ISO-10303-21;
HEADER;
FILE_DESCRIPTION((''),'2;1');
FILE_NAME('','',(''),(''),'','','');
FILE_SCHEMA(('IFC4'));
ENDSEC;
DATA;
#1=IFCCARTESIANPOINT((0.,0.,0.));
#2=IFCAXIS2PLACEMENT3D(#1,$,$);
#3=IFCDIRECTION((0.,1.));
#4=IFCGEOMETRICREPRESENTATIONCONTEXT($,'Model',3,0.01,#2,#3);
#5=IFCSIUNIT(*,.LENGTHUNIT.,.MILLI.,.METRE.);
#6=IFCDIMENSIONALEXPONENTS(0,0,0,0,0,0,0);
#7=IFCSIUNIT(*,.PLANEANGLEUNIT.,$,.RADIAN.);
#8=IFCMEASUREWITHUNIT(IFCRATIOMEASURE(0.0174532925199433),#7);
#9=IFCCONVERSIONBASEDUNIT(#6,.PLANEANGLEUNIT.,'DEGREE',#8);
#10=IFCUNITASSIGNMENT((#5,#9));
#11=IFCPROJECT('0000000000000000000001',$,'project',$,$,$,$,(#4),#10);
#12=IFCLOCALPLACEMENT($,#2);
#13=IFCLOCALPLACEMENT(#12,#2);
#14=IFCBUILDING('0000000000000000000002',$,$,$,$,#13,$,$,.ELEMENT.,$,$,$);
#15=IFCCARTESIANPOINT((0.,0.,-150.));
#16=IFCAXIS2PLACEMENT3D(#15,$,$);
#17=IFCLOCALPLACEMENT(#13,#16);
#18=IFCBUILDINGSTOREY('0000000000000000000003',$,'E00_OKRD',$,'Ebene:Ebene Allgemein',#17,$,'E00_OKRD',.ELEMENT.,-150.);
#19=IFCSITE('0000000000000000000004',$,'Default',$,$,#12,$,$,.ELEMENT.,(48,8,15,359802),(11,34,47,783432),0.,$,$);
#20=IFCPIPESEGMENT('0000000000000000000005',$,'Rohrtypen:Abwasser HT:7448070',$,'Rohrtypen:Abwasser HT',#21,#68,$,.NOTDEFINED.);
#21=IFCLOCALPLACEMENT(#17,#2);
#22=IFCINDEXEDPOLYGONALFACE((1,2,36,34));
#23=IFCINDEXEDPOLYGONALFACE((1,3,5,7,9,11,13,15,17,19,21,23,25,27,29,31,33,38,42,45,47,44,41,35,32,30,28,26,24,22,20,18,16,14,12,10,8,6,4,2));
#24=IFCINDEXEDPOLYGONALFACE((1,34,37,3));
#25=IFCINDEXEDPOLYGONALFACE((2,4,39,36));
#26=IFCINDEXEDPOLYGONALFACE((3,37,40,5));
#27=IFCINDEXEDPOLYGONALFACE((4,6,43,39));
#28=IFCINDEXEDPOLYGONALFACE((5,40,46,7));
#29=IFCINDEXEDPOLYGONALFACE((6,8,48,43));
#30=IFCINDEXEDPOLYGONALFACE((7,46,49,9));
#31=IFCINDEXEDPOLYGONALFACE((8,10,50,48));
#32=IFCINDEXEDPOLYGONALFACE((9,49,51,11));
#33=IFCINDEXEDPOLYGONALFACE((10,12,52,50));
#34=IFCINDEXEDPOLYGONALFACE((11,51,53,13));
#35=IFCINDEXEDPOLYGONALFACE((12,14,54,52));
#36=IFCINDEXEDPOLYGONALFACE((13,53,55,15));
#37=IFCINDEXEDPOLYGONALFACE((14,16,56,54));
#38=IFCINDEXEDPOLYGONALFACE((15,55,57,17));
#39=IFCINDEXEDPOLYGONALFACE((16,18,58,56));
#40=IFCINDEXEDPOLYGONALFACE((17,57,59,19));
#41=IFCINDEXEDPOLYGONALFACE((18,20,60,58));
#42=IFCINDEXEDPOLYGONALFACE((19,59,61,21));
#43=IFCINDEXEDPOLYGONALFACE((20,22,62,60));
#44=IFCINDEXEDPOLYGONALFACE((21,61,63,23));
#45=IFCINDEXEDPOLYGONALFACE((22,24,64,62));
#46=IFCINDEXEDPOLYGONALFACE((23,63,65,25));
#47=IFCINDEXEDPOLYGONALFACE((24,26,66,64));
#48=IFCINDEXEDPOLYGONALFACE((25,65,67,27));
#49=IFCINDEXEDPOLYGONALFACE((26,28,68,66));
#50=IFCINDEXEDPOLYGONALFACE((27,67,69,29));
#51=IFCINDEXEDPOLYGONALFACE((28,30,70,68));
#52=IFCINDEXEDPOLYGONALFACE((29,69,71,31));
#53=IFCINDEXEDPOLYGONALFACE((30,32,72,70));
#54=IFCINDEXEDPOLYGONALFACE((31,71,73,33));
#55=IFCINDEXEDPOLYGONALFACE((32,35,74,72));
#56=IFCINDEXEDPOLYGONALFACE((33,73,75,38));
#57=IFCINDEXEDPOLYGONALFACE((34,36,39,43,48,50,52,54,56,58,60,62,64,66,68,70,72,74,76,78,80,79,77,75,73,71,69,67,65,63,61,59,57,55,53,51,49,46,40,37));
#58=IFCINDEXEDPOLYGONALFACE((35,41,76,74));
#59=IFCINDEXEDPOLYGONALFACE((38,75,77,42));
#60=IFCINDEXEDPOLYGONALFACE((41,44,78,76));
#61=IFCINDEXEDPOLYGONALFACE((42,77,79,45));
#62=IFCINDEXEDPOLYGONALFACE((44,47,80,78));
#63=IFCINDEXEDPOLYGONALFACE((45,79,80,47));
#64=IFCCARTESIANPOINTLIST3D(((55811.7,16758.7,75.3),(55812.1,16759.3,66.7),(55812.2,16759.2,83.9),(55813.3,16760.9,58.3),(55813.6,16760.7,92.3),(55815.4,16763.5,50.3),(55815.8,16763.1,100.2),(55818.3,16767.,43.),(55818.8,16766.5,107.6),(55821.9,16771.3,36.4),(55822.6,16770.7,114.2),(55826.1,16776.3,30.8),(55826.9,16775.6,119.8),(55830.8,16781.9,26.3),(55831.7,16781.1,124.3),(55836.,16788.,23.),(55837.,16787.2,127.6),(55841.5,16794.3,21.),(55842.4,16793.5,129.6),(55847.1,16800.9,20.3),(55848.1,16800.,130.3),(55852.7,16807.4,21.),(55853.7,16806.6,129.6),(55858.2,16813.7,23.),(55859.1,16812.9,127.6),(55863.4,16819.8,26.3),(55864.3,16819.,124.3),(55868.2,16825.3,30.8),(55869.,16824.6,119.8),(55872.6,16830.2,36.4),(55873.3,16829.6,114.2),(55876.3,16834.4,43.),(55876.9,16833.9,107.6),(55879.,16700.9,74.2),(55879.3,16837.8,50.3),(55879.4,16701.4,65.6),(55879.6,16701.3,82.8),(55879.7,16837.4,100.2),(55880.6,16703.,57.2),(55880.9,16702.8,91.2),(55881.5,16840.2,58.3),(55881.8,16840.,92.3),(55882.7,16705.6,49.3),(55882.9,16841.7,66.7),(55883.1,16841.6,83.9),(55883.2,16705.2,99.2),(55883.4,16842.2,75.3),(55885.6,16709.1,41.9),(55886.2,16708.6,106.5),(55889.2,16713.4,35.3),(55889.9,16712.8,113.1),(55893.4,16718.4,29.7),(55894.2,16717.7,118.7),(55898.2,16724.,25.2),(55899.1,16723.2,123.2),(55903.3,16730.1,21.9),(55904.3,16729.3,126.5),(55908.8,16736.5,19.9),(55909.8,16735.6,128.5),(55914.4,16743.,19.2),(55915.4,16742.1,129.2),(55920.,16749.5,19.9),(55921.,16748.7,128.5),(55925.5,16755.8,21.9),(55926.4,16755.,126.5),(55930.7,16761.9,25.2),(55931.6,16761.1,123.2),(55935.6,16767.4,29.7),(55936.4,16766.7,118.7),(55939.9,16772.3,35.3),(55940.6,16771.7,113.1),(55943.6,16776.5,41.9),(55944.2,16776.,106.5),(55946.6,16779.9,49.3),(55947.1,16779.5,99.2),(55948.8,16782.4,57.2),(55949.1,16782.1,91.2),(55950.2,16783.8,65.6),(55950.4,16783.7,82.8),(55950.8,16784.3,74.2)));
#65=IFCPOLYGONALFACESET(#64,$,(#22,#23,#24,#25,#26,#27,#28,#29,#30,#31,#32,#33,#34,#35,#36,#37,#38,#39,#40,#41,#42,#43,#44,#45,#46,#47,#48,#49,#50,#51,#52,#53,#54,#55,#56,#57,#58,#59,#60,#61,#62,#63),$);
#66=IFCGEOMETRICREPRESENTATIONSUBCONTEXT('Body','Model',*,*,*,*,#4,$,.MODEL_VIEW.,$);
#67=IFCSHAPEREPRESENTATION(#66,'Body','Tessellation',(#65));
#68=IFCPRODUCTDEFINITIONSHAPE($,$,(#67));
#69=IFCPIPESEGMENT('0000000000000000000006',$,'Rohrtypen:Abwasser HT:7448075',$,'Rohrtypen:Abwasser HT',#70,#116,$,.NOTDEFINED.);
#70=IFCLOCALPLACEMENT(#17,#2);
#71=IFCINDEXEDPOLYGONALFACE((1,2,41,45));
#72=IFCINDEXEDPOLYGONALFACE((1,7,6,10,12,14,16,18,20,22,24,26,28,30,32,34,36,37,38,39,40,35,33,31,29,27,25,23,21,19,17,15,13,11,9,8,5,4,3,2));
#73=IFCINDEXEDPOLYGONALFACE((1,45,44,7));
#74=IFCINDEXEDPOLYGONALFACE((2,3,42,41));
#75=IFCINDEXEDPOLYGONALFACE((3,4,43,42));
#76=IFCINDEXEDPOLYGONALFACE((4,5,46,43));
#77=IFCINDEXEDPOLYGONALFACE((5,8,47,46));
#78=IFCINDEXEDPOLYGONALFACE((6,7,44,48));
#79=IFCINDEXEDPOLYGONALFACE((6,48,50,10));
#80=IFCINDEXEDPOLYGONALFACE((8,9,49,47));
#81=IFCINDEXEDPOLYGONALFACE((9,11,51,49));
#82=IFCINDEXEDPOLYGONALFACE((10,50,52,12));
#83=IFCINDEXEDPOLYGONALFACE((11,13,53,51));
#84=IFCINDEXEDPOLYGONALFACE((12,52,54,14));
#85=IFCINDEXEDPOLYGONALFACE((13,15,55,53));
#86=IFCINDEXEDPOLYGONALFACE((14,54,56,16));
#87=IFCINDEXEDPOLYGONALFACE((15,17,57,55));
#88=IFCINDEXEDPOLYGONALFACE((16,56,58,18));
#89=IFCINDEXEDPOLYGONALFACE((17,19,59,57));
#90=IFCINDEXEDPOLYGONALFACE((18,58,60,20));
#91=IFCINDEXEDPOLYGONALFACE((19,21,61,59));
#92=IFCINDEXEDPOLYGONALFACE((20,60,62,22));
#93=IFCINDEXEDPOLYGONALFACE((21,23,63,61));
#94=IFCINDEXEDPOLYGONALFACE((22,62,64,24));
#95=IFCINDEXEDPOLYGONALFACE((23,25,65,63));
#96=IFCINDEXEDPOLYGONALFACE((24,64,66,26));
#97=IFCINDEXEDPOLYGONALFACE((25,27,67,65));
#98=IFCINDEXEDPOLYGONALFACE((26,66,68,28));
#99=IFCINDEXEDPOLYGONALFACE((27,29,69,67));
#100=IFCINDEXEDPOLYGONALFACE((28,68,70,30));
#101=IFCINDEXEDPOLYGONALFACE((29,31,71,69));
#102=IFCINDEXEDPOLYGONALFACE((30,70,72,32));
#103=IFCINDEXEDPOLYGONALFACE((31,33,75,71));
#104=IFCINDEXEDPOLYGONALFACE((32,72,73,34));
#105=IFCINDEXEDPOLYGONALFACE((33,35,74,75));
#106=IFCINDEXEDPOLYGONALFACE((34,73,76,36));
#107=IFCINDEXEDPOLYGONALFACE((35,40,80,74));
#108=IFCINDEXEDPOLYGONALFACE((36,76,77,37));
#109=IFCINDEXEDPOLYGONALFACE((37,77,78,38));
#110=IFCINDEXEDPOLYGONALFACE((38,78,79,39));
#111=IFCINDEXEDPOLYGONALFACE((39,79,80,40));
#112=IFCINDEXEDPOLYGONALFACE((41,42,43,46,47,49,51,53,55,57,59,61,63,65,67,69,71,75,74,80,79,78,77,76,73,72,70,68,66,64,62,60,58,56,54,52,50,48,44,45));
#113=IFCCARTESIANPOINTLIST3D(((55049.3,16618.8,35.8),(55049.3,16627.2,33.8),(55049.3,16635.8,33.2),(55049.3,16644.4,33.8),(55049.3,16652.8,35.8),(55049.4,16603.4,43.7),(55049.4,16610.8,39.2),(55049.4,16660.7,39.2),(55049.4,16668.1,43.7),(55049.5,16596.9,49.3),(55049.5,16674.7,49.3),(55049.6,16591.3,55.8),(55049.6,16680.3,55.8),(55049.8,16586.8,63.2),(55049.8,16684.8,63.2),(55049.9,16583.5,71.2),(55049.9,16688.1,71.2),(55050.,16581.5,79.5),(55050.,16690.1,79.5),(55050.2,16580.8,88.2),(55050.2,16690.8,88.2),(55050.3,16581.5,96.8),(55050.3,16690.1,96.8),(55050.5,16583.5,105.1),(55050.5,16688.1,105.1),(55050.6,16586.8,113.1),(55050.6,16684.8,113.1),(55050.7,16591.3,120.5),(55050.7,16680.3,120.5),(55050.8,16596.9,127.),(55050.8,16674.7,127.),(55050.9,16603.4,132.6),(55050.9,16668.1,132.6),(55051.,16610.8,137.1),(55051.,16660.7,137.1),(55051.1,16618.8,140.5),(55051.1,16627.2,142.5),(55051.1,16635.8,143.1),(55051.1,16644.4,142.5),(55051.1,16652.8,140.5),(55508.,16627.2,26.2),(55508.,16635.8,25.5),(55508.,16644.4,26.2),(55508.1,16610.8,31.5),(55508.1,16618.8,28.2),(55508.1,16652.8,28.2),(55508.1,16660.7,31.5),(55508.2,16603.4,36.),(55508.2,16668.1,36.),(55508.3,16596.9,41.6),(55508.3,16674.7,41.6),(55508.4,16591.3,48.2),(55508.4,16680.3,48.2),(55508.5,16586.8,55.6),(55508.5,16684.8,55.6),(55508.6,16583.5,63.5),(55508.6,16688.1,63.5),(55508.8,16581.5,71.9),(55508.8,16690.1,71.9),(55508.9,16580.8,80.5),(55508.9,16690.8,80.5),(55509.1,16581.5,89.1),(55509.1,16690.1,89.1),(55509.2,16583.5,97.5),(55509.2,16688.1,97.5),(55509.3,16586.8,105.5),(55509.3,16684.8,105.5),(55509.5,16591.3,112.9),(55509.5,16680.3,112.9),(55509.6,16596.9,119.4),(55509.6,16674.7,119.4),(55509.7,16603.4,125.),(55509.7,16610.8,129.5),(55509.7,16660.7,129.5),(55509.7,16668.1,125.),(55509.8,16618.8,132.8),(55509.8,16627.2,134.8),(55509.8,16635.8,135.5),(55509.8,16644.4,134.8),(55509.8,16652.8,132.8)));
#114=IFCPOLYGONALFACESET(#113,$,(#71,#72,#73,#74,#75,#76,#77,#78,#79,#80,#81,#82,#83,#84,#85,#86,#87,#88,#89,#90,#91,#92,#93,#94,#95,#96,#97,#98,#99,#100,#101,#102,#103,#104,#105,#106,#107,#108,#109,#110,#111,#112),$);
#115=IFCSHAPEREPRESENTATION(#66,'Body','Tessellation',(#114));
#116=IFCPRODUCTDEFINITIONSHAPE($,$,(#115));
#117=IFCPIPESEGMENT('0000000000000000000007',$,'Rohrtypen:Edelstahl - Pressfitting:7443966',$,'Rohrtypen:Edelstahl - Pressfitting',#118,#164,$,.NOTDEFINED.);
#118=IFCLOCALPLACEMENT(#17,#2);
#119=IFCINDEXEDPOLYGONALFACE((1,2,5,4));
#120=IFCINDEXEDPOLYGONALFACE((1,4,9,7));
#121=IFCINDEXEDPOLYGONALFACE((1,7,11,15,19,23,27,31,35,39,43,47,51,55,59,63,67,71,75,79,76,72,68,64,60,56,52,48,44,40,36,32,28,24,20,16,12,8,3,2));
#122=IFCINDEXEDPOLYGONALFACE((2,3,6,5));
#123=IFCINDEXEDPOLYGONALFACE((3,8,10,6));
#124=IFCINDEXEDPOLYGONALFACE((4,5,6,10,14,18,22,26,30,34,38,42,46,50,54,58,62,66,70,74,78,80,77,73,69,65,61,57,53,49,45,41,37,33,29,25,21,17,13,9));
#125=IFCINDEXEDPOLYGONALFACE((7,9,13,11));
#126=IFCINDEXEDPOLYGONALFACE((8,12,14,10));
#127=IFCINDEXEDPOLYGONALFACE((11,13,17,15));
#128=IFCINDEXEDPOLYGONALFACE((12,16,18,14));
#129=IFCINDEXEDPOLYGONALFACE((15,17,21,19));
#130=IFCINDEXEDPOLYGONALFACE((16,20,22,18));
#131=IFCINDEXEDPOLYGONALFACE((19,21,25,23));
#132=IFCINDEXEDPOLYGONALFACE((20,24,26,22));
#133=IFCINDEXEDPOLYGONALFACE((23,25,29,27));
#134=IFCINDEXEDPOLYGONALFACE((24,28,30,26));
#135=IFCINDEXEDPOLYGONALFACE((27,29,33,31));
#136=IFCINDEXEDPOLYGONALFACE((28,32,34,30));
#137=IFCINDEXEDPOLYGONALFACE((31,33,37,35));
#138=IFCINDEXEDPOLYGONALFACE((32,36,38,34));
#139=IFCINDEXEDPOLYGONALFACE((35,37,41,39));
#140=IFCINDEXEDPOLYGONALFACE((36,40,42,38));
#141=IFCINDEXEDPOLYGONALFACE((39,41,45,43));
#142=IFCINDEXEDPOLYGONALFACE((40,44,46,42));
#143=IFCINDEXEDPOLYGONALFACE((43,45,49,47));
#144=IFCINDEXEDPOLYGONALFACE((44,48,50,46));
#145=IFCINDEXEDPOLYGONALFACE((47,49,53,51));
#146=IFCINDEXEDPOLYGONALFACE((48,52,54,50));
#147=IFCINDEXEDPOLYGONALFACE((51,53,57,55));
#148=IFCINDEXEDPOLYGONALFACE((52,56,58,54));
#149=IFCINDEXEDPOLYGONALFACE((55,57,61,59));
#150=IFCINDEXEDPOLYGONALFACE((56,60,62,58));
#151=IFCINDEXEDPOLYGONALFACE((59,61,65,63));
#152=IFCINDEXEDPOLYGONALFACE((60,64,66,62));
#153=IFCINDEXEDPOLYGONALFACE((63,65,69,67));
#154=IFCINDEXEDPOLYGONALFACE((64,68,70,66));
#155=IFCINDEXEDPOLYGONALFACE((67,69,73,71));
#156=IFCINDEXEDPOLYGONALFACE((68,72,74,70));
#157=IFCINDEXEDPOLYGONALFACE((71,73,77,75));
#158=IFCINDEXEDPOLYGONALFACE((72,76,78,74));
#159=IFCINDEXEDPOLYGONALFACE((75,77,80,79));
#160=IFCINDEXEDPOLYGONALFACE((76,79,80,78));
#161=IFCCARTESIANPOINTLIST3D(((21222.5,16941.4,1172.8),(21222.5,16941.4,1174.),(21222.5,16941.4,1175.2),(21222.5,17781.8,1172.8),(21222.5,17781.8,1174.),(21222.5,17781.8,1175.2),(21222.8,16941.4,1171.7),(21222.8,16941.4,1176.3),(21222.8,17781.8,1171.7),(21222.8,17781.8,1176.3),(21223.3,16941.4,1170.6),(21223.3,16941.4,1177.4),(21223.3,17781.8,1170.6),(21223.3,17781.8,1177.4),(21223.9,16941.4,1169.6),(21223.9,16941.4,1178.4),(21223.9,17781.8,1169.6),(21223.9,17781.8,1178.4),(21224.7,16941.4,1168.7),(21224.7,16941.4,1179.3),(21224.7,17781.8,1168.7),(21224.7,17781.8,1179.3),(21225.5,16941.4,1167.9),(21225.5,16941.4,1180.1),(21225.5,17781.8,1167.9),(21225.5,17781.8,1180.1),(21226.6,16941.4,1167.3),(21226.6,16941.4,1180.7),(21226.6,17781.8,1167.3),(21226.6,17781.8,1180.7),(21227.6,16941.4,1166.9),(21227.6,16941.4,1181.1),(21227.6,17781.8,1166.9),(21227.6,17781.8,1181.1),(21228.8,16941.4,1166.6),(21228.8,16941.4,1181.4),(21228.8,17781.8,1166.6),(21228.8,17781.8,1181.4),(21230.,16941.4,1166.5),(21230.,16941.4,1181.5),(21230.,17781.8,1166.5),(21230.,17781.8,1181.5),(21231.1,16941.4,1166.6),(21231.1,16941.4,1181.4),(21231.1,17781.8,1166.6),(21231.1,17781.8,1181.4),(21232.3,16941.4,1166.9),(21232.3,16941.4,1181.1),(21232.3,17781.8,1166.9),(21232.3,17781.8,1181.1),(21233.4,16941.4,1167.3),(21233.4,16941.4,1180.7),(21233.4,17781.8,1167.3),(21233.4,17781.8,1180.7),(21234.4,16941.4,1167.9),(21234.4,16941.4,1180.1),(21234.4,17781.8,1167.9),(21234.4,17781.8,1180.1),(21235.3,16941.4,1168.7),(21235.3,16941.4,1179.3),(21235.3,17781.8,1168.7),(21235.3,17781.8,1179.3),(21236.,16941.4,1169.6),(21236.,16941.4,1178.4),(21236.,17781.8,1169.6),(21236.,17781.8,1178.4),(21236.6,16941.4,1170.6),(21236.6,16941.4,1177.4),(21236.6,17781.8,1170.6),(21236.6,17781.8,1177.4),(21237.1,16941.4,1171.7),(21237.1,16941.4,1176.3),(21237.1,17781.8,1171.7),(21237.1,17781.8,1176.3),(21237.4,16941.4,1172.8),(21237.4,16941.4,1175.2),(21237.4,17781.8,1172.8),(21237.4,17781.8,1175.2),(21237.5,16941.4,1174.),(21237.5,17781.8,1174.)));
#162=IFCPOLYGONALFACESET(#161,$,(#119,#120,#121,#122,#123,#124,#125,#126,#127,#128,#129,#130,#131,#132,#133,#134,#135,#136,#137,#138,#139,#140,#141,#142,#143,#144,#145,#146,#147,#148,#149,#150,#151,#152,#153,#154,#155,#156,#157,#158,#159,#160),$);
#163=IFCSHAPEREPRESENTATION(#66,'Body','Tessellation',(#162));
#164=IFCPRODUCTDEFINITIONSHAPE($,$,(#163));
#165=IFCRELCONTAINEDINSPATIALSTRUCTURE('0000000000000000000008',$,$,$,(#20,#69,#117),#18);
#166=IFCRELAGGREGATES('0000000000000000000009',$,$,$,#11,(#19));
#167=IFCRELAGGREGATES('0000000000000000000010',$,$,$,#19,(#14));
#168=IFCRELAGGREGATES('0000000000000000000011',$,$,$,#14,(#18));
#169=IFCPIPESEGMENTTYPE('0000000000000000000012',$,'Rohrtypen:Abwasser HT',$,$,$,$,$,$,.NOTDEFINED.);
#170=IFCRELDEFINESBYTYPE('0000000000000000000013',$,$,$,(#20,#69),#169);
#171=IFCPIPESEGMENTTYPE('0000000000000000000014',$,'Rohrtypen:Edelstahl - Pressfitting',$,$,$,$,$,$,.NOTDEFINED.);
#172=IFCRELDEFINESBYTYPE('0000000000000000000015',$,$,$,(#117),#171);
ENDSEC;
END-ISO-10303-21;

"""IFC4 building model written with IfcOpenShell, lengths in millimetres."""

from ifc_helpers import new_model, entity, si_unit, converted_unit, direction, frame, origin, place, context, subcontext, project, spatial, indexed_curve, outline, extrude, type_object, element, save


model = new_model("IFC4")

# Units and contexts
model_context = context("Model", 3, precision=0.01, world=origin(), true_north=direction((0.0, 1.0)))
body_context = subcontext(model_context, "Body", "Model", "MODEL_VIEW")
ifc_project = project(units=[si_unit("LENGTHUNIT", "METRE", prefix="MILLI"), converted_unit("PLANEANGLEUNIT", "DEGREE", entity("IfcRatioMeasure", 0.0174532925199433), si_unit("PLANEANGLEUNIT", "RADIAN"), dimensions=[0, 0, 0, 0, 0, 0, 0])], contexts=[model_context])

# Site, building, storey
site_placement = place(None, origin())
site = spatial("IfcSite", under=ifc_project, at=site_placement, Name="Default", CompositionType="ELEMENT", RefLatitude=(48, 8, 15, 359802), RefLongitude=(11, 34, 47, 783432), RefElevation=0.0)
building_placement = place(site_placement, origin())
building = spatial("IfcBuilding", under=site, at=building_placement, CompositionType="ELEMENT")
storey_placement = place(building_placement, frame((0.0, 0.0, -150.0)))
storey = spatial("IfcBuildingStorey", under=building, at=storey_placement, Name="E00_OKRD", ObjectType="Ebene:Ebene Allgemein", LongName="E00_OKRD", CompositionType="ELEMENT", Elevation=-150.0)

# Pipe segments
pipe_segment_type_1 = type_object("IfcPipeSegmentType", Name="Rohrtypen:Abwasser HT", PredefinedType="NOTDEFINED")
pipe_segment_1_placement = place(storey_placement, origin())
element("IfcPipeSegment", 1, at=pipe_segment_1_placement, inside=storey, type_object=pipe_segment_type_1, Name="Rohrtypen:Abwasser HT:7448070", ObjectType="Rohrtypen:Abwasser HT", PredefinedType="NOTDEFINED", context=body_context, shape_type="SweptSolid", body=[
    extrude(outline(indexed_curve([(55.0, 0.0), (54.3, 8.6), (52.3, 17.0), (49.0, 25.0), (44.5, 32.3), (38.9, 38.9), (32.3, 44.5), (25.0, 49.0), (17.0, 52.3), (8.6, 54.3), (0.0, 55.0), (-8.6, 54.3), (-17.0, 52.3), (-25.0, 49.0), (-32.3, 44.5), (-38.9, 38.9), (-44.5, 32.3), (-49.0, 25.0), (-52.3, 17.0), (-54.3, 8.6), (-55.0, 0.0), (-54.3, -8.6), (-52.3, -17.0), (-49.0, -25.0), (-44.5, -32.3), (-38.9, -38.9), (-32.3, -44.5), (-25.0, -49.0), (-17.0, -52.3), (-8.6, -54.3), (0.0, -55.0), (8.6, -54.3), (17.0, -52.3), (25.0, -49.0), (32.3, -44.5), (38.9, -38.9), (44.5, -32.3), (49.0, -25.0), (52.3, -17.0), (54.3, -8.6), (55.0, 0.0)], self_intersect=False)), frame((55914.9, 16742.6, 74.2), z_axis=(-0.758188, 0.651928, 0.011871), x_axis=(-0.651974, -0.758242, 0.0)), (0.0, 0.0, 1.0), 88.8),
])
pipe_segment_2_placement = place(storey_placement, origin())
element("IfcPipeSegment", 2, at=pipe_segment_2_placement, inside=storey, type_object=pipe_segment_type_1, Name="Rohrtypen:Abwasser HT:7448075", ObjectType="Rohrtypen:Abwasser HT", PredefinedType="NOTDEFINED", context=body_context, shape_type="SweptSolid", body=[
    extrude(outline(indexed_curve([(55.0, 0.0), (54.3, 8.6), (52.3, 17.0), (49.0, 25.0), (44.5, 32.3), (38.9, 38.9), (32.3, 44.5), (25.0, 49.0), (17.0, 52.3), (8.6, 54.3), (0.0, 55.0), (-8.6, 54.3), (-17.0, 52.3), (-25.0, 49.0), (-32.3, 44.5), (-38.9, 38.9), (-44.5, 32.3), (-49.0, 25.0), (-52.3, 17.0), (-54.3, 8.6), (-55.0, 0.0), (-54.3, -8.6), (-52.3, -17.0), (-49.0, -25.0), (-44.5, -32.3), (-38.9, -38.9), (-32.3, -44.5), (-25.0, -49.0), (-17.0, -52.3), (-8.6, -54.3), (0.0, -55.0), (8.6, -54.3), (17.0, -52.3), (25.0, -49.0), (32.3, -44.5), (38.9, -38.9), (44.5, -32.3), (49.0, -25.0), (52.3, -17.0), (54.3, -8.6), (55.0, 0.0)], self_intersect=False)), frame((55050.2, 16635.8, 88.2), z_axis=(0.999862, 0.0, -0.016604), x_axis=(0.0, -1.0, 0.0)), (0.0, 0.0, 1.0), 458.8),
])
pipe_segment_type_2 = type_object("IfcPipeSegmentType", Name="Rohrtypen:Edelstahl - Pressfitting", PredefinedType="NOTDEFINED")
pipe_segment_3_placement = place(storey_placement, origin())
element("IfcPipeSegment", 3, at=pipe_segment_3_placement, inside=storey, type_object=pipe_segment_type_2, Name="Rohrtypen:Edelstahl - Pressfitting:7443966", ObjectType="Rohrtypen:Edelstahl - Pressfitting", PredefinedType="NOTDEFINED", context=body_context, shape_type="SweptSolid", body=[
    extrude(outline(indexed_curve([(7.5, 0.0), (7.4, 1.2), (7.1, 2.3), (6.7, 3.4), (6.1, 4.4), (5.3, 5.3), (4.4, 6.1), (3.4, 6.7), (2.3, 7.1), (1.2, 7.4), (0.0, 7.5), (-1.2, 7.4), (-2.3, 7.1), (-3.4, 6.7), (-4.4, 6.1), (-5.3, 5.3), (-6.1, 4.4), (-6.7, 3.4), (-7.1, 2.3), (-7.4, 1.2), (-7.5, 0.0), (-7.4, -1.2), (-7.1, -2.3), (-6.7, -3.4), (-6.1, -4.4), (-5.3, -5.3), (-4.4, -6.1), (-3.4, -6.7), (-2.3, -7.1), (-1.2, -7.4), (0.0, -7.5), (1.2, -7.4), (2.3, -7.1), (3.4, -6.7), (4.4, -6.1), (5.3, -5.3), (6.1, -4.4), (6.7, -3.4), (7.1, -2.3), (7.4, -1.2), (7.5, 0.0)], self_intersect=False)), frame((21230.0, 16941.4, 1174.0), z_axis=(0.0, 1.0, 0.000004), x_axis=(-1.0, 0.0, 0.0)), (0.0, 0.0, 1.0), 840.4),
])

save(model, "model.ifc")
